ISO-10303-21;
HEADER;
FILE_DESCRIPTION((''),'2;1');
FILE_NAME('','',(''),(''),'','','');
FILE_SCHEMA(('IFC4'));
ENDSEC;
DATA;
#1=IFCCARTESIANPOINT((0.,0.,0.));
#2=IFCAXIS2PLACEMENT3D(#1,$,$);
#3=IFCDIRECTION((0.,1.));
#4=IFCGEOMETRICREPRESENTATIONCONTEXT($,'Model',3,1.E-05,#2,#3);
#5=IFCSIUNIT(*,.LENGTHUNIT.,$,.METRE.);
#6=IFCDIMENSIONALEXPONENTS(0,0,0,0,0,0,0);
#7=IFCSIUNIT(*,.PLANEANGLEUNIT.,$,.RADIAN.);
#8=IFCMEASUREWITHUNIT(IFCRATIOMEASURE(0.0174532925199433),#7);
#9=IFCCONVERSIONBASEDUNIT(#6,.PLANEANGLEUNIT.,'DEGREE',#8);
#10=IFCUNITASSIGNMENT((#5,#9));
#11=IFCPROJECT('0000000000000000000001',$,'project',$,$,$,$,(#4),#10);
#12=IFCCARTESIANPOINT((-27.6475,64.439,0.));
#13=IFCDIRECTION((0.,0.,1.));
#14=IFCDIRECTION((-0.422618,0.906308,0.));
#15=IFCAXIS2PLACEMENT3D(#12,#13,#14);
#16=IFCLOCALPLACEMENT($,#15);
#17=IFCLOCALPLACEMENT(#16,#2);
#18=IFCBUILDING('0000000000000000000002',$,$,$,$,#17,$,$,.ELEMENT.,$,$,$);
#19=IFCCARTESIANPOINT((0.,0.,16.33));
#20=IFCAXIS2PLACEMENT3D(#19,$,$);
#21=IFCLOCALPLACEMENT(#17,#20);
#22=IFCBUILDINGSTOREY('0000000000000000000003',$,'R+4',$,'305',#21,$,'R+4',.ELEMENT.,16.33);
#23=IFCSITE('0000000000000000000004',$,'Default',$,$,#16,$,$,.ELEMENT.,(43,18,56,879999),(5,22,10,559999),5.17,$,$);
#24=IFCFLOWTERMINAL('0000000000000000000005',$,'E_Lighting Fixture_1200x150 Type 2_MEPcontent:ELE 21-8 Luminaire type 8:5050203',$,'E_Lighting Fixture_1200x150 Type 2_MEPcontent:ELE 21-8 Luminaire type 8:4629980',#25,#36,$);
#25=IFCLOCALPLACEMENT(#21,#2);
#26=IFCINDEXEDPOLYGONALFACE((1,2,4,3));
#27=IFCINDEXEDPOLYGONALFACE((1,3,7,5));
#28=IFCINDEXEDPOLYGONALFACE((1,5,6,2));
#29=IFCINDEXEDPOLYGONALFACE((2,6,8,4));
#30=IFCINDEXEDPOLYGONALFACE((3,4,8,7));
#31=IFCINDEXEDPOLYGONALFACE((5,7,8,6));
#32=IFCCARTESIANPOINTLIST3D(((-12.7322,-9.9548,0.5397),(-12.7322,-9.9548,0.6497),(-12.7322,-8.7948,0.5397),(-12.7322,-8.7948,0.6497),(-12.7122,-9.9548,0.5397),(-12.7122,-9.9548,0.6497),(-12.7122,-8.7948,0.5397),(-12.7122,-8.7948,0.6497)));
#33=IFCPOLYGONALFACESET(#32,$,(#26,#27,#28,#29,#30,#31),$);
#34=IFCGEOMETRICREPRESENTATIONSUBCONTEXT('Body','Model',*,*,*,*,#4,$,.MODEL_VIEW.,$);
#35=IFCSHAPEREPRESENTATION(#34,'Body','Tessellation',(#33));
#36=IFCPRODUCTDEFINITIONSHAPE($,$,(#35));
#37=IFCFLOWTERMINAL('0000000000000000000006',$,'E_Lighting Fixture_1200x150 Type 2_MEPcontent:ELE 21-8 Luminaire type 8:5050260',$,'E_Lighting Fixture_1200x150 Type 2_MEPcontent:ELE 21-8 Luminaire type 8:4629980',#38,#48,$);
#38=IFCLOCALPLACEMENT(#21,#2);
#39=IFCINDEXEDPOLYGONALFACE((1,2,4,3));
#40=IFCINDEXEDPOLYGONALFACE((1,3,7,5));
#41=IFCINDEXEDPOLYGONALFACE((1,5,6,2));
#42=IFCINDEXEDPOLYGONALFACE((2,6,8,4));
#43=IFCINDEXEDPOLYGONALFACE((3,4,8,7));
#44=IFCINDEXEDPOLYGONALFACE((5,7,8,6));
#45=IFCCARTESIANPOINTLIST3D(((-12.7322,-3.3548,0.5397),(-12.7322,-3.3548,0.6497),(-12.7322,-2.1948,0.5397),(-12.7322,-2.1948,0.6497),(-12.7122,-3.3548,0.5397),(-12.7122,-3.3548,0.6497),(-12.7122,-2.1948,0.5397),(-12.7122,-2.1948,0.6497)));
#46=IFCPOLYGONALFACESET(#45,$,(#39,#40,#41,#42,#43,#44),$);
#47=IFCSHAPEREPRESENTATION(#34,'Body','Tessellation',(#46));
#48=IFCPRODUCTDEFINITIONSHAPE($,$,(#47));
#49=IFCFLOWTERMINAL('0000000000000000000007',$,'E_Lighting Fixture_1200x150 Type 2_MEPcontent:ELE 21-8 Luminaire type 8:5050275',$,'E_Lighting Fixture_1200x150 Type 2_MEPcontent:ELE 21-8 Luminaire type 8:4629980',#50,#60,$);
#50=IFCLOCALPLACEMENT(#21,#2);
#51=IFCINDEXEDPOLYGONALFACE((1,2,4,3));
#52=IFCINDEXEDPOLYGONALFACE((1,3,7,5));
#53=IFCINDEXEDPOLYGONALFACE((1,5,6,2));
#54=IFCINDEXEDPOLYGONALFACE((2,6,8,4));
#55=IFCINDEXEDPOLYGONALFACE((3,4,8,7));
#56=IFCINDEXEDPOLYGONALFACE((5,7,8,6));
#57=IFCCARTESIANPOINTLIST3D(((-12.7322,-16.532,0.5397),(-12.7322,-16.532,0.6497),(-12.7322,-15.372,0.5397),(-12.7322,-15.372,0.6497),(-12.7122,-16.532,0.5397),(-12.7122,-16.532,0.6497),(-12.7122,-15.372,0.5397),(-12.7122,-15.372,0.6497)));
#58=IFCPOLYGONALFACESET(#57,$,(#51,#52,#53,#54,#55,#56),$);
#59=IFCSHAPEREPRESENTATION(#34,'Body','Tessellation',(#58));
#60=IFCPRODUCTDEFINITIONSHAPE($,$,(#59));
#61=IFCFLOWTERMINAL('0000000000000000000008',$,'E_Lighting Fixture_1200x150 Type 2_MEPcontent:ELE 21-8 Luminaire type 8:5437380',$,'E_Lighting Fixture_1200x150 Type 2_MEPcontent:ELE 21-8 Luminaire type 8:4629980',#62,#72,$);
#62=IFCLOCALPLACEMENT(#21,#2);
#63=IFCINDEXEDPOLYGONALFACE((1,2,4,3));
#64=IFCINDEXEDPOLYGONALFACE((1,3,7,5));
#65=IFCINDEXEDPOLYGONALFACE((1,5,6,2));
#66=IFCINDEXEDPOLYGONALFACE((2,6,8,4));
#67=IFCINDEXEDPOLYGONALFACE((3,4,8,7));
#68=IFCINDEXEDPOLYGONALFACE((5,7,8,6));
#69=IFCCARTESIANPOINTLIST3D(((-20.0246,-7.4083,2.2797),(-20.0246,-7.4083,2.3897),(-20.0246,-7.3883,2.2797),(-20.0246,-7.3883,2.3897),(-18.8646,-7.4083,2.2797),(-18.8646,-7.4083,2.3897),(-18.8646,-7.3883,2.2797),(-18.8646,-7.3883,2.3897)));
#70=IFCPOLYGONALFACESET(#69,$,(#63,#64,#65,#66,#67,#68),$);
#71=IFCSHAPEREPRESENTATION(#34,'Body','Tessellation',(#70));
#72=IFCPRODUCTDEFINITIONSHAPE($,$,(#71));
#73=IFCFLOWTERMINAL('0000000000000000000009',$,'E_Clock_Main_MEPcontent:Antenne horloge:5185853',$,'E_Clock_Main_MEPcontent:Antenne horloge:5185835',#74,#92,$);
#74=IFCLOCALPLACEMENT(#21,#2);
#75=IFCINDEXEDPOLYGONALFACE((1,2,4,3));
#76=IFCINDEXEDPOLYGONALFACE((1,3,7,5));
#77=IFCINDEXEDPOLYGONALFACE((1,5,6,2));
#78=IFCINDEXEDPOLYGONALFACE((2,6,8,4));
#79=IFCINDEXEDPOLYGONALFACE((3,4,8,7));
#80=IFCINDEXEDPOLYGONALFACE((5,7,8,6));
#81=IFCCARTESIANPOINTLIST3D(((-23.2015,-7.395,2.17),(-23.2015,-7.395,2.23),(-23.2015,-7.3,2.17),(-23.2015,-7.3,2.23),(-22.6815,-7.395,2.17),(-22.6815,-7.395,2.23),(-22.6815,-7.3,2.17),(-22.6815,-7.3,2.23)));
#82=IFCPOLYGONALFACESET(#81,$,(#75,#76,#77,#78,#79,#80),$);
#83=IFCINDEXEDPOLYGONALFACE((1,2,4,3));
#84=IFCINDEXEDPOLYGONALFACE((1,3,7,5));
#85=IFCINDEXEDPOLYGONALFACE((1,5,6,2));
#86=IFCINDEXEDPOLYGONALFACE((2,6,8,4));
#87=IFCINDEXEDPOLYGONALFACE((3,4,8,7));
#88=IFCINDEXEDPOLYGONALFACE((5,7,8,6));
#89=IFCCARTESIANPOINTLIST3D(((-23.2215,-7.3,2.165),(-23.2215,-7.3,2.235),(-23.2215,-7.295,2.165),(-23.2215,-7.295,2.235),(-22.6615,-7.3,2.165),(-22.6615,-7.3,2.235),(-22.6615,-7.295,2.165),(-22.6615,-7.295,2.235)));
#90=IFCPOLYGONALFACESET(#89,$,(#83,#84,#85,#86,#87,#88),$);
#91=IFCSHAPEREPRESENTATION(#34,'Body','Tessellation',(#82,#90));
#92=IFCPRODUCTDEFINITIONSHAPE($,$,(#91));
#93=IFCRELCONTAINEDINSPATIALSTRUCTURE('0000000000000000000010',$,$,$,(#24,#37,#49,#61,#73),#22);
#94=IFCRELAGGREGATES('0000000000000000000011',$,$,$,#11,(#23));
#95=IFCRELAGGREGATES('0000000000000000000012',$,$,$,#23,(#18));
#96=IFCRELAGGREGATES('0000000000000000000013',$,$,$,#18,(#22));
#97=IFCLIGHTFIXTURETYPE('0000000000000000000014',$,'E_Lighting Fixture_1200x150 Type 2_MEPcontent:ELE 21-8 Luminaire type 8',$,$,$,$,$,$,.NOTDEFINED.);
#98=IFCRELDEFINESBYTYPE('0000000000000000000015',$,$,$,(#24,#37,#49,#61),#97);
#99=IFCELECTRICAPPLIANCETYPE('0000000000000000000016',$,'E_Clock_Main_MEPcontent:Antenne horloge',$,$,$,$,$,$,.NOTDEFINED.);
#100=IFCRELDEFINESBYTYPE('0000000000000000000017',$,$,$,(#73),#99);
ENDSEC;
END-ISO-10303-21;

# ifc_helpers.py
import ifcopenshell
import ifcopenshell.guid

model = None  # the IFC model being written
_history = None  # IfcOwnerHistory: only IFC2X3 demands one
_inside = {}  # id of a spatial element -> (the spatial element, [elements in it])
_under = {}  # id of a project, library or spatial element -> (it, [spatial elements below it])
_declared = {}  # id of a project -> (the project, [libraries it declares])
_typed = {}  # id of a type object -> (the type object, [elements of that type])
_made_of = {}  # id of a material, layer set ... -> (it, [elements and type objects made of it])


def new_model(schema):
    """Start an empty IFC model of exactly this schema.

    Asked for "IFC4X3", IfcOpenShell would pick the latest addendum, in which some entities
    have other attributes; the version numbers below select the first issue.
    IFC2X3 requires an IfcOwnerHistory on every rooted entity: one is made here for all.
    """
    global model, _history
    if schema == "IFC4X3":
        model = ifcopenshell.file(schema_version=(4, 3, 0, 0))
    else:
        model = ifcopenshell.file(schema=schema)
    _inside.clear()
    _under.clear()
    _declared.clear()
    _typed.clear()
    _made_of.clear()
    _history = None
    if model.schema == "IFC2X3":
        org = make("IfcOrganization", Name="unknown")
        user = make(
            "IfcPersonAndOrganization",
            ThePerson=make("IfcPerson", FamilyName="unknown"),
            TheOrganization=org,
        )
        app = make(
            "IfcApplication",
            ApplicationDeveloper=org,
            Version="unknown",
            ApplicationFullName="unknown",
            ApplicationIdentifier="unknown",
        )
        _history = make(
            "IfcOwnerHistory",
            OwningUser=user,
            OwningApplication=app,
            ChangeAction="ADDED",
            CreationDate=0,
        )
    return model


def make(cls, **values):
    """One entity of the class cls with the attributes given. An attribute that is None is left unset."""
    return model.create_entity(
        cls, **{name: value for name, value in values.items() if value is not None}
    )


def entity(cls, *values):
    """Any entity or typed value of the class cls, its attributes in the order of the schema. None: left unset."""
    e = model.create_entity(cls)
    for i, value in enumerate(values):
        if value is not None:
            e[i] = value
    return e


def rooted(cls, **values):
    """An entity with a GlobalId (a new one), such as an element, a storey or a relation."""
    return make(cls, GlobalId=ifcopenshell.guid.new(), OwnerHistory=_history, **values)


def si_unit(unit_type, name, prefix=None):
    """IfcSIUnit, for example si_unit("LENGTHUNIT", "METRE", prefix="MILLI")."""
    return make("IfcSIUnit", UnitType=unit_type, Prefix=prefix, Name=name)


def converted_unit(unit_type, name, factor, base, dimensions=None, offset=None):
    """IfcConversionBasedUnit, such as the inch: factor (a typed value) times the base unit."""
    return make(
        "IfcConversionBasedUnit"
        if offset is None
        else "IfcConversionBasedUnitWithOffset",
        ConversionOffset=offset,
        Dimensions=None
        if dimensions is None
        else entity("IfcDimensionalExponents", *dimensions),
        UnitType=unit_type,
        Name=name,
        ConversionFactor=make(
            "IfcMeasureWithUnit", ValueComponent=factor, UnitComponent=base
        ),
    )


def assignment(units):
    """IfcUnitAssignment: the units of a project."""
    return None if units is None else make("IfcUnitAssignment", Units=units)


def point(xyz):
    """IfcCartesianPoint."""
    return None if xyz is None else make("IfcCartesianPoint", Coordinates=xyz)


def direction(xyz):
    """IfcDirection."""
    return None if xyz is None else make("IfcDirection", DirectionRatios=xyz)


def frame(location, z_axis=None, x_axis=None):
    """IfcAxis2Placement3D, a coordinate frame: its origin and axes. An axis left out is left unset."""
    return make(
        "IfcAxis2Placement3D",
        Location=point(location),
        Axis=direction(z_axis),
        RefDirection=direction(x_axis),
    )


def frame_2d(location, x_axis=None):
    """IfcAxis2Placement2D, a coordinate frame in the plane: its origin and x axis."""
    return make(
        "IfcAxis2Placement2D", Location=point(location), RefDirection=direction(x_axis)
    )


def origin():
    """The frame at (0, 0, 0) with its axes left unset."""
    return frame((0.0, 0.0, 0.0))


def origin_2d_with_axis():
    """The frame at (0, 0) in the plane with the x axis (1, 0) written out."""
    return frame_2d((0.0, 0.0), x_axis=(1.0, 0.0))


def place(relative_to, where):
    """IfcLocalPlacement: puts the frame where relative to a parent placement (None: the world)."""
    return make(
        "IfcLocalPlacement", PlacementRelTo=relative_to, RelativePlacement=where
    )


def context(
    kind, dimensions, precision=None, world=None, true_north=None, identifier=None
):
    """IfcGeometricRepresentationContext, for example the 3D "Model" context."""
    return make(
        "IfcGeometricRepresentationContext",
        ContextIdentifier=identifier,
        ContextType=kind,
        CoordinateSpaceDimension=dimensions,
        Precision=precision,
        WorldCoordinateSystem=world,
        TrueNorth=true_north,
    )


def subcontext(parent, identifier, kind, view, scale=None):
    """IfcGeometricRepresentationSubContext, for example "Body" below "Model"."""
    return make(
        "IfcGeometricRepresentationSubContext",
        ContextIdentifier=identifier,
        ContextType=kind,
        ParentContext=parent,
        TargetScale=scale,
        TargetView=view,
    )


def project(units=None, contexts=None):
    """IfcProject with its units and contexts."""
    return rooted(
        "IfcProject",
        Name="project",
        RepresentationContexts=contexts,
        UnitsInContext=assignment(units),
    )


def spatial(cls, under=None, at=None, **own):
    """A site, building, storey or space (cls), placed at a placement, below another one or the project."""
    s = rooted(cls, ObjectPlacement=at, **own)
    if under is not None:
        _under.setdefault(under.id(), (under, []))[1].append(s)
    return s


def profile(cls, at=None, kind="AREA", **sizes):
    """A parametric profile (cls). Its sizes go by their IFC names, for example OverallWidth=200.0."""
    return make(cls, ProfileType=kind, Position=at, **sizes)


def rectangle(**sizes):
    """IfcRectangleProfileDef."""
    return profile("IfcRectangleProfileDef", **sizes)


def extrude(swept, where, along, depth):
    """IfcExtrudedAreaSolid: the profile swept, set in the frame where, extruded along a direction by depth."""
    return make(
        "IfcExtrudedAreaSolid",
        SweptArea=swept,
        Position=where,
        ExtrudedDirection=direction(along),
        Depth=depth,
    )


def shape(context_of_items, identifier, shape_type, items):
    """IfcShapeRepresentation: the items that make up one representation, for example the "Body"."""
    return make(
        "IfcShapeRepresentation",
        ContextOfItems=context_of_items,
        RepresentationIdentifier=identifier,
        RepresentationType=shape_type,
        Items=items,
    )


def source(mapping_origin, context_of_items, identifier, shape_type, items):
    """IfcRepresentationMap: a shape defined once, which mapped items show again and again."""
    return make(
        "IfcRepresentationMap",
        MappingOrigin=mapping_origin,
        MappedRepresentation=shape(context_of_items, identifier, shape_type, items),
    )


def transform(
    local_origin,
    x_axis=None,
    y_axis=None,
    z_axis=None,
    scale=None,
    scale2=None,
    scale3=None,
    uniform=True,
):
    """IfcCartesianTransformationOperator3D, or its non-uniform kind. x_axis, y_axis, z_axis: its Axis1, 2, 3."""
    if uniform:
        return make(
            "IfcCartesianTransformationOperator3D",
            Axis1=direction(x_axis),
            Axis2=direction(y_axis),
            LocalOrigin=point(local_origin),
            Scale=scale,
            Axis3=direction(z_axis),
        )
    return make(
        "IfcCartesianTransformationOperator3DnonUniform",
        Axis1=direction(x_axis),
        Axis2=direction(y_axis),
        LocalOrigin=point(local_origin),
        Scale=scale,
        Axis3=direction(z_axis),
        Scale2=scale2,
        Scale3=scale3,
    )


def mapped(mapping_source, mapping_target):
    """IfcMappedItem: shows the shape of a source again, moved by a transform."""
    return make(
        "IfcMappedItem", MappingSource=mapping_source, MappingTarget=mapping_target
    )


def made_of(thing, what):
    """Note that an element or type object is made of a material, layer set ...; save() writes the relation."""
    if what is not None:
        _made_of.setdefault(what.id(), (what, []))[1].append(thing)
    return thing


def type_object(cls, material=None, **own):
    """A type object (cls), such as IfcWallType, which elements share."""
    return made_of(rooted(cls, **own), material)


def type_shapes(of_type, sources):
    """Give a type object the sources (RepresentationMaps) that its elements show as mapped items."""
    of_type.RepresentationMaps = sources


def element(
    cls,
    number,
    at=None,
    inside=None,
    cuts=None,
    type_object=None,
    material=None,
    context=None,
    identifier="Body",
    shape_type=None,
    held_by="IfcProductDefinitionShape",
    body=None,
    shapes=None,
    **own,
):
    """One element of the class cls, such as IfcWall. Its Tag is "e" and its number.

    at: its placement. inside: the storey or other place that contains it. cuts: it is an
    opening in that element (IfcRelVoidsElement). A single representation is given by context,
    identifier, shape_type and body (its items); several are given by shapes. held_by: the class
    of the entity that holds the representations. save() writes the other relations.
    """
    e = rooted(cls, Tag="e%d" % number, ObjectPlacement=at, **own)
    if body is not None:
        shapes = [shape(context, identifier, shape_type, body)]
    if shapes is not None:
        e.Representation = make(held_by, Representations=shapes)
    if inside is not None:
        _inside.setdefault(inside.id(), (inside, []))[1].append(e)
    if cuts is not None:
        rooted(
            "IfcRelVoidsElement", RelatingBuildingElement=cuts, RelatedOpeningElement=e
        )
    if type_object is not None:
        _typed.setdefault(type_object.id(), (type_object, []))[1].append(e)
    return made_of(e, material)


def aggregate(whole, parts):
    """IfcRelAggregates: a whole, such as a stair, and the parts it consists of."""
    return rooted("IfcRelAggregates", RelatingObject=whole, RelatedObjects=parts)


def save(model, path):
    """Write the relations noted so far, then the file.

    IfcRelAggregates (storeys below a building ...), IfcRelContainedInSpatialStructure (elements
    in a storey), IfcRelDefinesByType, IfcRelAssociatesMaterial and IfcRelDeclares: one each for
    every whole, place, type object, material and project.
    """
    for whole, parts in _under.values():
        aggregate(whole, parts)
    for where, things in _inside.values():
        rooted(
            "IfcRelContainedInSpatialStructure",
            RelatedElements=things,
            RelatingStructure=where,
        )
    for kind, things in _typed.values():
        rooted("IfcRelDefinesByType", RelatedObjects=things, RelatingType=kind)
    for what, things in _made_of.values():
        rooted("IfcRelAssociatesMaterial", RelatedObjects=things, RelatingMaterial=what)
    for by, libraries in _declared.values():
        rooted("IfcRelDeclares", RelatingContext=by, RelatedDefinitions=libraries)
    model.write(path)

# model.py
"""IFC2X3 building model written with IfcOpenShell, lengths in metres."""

from ifc_helpers import new_model, entity, si_unit, converted_unit, direction, frame, frame_2d, origin, origin_2d_with_axis, place, context, subcontext, project, spatial, rectangle, extrude, source, transform, mapped, type_object, type_shapes, element, save


model = new_model("IFC2X3")

# Units and contexts
model_context = context("Model", 3, precision=1e-05, world=origin(), true_north=direction((0.0, 1.0)))
body_context = subcontext(model_context, "Body", "Model", "MODEL_VIEW")
ifc_project = project(units=[si_unit("LENGTHUNIT", "METRE"), converted_unit("PLANEANGLEUNIT", "DEGREE", entity("IfcRatioMeasure", 0.0174532925199433), si_unit("PLANEANGLEUNIT", "RADIAN"), dimensions=[0, 0, 0, 0, 0, 0, 0])], contexts=[model_context])

# Site, building, storey
site_placement = place(None, frame((-27.6475, 64.439, 0.0), z_axis=(0.0, 0.0, 1.0), x_axis=(-0.422618, 0.906308, 0.0)))
site = spatial("IfcSite", under=ifc_project, at=site_placement, Name="Default", CompositionType="ELEMENT", RefLatitude=(43, 18, 56, 879999), RefLongitude=(5, 22, 10, 559999), RefElevation=5.17)
building_placement = place(site_placement, origin())
building = spatial("IfcBuilding", under=site, at=building_placement, CompositionType="ELEMENT")
storey_placement = place(building_placement, frame((0.0, 0.0, 16.33)))
storey = spatial("IfcBuildingStorey", under=building, at=storey_placement, Name="R+4", ObjectType="305", LongName="R+4", CompositionType="ELEMENT", Elevation=16.33)

# Flow terminals
light_fixture_type = type_object("IfcLightFixtureType", Name="E_Lighting Fixture_1200x150 Type 2_MEPcontent:ELE 21-8 Luminaire type 8", PredefinedType="NOTDEFINED")
shared_shape_1 = source(origin(), body_context, "Body", "SweptSolid", [
    extrude(rectangle(XDim=0.02, YDim=1.16, at=frame_2d((0.0, 0.0), x_axis=(1.0, 0.0))), frame((0.0, 0.01, -0.055), z_axis=(0.0, 0.0, 1.0), x_axis=(0.0, -1.0, 0.0)), (0.0, 0.0, 1.0), 0.11),
])
type_shapes(light_fixture_type, [shared_shape_1])
for number, where, z_axis, x_axis, name in (
    (1, (-12.7322, -9.3748, 0.5947), (0.0, 0.0, 1.0), (0.0, -1.0, 0.0), "E_Lighting Fixture_1200x150 Type 2_MEPcontent:ELE 21-8 Luminaire type 8:5050203"),
    (2, (-12.7322, -2.7748, 0.5947), (0.0, 0.0, 1.0), (0.0, -1.0, 0.0), "E_Lighting Fixture_1200x150 Type 2_MEPcontent:ELE 21-8 Luminaire type 8:5050260"),
    (3, (-12.7322, -15.952, 0.5947), (0.0, 0.0, 1.0), (0.0, -1.0, 0.0), "E_Lighting Fixture_1200x150 Type 2_MEPcontent:ELE 21-8 Luminaire type 8:5050275"),
    (4, (-19.4446, -7.3883, 2.3347), (0.0, 0.0, 1.0), (-1.0, 0.0, 0.0), "E_Lighting Fixture_1200x150 Type 2_MEPcontent:ELE 21-8 Luminaire type 8:5437380"),
):
    element("IfcFlowTerminal", number, at=place(storey_placement, frame(where, z_axis=z_axis, x_axis=x_axis)), inside=storey, type_object=light_fixture_type, Name=name, ObjectType="E_Lighting Fixture_1200x150 Type 2_MEPcontent:ELE 21-8 Luminaire type 8:4629980", context=body_context, shape_type="MappedRepresentation", body=[
        mapped(shared_shape_1, transform((0.0, 0.0, 0.0), scale=1.0)),
    ])
electric_appliance_type = type_object("IfcElectricApplianceType", Name="E_Clock_Main_MEPcontent:Antenne horloge", PredefinedType="NOTDEFINED")
shared_shape_2 = source(origin(), body_context, "Body", "SweptSolid", [
    extrude(rectangle(XDim=0.095, YDim=0.52, at=frame_2d((0.0, 0.0), x_axis=(1.0, 0.0))), frame((0.0, 0.0475, -0.03), z_axis=(0.0, 0.0, 1.0), x_axis=(0.0, 1.0, 0.0)), (0.0, 0.0, 1.0), 0.06),
    extrude(rectangle(XDim=0.005, YDim=0.56, at=origin_2d_with_axis()), frame((0.0, -0.0025, -0.035), z_axis=(0.0, 0.0, 1.0), x_axis=(0.0, 1.0, 0.0)), (0.0, 0.0, 1.0), 0.07),
])
type_shapes(electric_appliance_type, [shared_shape_2])
flow_terminal_placement = place(storey_placement, frame((-22.9415, -7.3, 2.2), z_axis=(0.0, 0.0, 1.0), x_axis=(-1.0, 0.0, 0.0)))
element("IfcFlowTerminal", 5, at=flow_terminal_placement, inside=storey, type_object=electric_appliance_type, Name="E_Clock_Main_MEPcontent:Antenne horloge:5185853", ObjectType="E_Clock_Main_MEPcontent:Antenne horloge:5185835", context=body_context, shape_type="MappedRepresentation", body=[
    mapped(shared_shape_2, transform((0.0, 0.0, 0.0), scale=1.0)),
])

save(model, "model.ifc")
